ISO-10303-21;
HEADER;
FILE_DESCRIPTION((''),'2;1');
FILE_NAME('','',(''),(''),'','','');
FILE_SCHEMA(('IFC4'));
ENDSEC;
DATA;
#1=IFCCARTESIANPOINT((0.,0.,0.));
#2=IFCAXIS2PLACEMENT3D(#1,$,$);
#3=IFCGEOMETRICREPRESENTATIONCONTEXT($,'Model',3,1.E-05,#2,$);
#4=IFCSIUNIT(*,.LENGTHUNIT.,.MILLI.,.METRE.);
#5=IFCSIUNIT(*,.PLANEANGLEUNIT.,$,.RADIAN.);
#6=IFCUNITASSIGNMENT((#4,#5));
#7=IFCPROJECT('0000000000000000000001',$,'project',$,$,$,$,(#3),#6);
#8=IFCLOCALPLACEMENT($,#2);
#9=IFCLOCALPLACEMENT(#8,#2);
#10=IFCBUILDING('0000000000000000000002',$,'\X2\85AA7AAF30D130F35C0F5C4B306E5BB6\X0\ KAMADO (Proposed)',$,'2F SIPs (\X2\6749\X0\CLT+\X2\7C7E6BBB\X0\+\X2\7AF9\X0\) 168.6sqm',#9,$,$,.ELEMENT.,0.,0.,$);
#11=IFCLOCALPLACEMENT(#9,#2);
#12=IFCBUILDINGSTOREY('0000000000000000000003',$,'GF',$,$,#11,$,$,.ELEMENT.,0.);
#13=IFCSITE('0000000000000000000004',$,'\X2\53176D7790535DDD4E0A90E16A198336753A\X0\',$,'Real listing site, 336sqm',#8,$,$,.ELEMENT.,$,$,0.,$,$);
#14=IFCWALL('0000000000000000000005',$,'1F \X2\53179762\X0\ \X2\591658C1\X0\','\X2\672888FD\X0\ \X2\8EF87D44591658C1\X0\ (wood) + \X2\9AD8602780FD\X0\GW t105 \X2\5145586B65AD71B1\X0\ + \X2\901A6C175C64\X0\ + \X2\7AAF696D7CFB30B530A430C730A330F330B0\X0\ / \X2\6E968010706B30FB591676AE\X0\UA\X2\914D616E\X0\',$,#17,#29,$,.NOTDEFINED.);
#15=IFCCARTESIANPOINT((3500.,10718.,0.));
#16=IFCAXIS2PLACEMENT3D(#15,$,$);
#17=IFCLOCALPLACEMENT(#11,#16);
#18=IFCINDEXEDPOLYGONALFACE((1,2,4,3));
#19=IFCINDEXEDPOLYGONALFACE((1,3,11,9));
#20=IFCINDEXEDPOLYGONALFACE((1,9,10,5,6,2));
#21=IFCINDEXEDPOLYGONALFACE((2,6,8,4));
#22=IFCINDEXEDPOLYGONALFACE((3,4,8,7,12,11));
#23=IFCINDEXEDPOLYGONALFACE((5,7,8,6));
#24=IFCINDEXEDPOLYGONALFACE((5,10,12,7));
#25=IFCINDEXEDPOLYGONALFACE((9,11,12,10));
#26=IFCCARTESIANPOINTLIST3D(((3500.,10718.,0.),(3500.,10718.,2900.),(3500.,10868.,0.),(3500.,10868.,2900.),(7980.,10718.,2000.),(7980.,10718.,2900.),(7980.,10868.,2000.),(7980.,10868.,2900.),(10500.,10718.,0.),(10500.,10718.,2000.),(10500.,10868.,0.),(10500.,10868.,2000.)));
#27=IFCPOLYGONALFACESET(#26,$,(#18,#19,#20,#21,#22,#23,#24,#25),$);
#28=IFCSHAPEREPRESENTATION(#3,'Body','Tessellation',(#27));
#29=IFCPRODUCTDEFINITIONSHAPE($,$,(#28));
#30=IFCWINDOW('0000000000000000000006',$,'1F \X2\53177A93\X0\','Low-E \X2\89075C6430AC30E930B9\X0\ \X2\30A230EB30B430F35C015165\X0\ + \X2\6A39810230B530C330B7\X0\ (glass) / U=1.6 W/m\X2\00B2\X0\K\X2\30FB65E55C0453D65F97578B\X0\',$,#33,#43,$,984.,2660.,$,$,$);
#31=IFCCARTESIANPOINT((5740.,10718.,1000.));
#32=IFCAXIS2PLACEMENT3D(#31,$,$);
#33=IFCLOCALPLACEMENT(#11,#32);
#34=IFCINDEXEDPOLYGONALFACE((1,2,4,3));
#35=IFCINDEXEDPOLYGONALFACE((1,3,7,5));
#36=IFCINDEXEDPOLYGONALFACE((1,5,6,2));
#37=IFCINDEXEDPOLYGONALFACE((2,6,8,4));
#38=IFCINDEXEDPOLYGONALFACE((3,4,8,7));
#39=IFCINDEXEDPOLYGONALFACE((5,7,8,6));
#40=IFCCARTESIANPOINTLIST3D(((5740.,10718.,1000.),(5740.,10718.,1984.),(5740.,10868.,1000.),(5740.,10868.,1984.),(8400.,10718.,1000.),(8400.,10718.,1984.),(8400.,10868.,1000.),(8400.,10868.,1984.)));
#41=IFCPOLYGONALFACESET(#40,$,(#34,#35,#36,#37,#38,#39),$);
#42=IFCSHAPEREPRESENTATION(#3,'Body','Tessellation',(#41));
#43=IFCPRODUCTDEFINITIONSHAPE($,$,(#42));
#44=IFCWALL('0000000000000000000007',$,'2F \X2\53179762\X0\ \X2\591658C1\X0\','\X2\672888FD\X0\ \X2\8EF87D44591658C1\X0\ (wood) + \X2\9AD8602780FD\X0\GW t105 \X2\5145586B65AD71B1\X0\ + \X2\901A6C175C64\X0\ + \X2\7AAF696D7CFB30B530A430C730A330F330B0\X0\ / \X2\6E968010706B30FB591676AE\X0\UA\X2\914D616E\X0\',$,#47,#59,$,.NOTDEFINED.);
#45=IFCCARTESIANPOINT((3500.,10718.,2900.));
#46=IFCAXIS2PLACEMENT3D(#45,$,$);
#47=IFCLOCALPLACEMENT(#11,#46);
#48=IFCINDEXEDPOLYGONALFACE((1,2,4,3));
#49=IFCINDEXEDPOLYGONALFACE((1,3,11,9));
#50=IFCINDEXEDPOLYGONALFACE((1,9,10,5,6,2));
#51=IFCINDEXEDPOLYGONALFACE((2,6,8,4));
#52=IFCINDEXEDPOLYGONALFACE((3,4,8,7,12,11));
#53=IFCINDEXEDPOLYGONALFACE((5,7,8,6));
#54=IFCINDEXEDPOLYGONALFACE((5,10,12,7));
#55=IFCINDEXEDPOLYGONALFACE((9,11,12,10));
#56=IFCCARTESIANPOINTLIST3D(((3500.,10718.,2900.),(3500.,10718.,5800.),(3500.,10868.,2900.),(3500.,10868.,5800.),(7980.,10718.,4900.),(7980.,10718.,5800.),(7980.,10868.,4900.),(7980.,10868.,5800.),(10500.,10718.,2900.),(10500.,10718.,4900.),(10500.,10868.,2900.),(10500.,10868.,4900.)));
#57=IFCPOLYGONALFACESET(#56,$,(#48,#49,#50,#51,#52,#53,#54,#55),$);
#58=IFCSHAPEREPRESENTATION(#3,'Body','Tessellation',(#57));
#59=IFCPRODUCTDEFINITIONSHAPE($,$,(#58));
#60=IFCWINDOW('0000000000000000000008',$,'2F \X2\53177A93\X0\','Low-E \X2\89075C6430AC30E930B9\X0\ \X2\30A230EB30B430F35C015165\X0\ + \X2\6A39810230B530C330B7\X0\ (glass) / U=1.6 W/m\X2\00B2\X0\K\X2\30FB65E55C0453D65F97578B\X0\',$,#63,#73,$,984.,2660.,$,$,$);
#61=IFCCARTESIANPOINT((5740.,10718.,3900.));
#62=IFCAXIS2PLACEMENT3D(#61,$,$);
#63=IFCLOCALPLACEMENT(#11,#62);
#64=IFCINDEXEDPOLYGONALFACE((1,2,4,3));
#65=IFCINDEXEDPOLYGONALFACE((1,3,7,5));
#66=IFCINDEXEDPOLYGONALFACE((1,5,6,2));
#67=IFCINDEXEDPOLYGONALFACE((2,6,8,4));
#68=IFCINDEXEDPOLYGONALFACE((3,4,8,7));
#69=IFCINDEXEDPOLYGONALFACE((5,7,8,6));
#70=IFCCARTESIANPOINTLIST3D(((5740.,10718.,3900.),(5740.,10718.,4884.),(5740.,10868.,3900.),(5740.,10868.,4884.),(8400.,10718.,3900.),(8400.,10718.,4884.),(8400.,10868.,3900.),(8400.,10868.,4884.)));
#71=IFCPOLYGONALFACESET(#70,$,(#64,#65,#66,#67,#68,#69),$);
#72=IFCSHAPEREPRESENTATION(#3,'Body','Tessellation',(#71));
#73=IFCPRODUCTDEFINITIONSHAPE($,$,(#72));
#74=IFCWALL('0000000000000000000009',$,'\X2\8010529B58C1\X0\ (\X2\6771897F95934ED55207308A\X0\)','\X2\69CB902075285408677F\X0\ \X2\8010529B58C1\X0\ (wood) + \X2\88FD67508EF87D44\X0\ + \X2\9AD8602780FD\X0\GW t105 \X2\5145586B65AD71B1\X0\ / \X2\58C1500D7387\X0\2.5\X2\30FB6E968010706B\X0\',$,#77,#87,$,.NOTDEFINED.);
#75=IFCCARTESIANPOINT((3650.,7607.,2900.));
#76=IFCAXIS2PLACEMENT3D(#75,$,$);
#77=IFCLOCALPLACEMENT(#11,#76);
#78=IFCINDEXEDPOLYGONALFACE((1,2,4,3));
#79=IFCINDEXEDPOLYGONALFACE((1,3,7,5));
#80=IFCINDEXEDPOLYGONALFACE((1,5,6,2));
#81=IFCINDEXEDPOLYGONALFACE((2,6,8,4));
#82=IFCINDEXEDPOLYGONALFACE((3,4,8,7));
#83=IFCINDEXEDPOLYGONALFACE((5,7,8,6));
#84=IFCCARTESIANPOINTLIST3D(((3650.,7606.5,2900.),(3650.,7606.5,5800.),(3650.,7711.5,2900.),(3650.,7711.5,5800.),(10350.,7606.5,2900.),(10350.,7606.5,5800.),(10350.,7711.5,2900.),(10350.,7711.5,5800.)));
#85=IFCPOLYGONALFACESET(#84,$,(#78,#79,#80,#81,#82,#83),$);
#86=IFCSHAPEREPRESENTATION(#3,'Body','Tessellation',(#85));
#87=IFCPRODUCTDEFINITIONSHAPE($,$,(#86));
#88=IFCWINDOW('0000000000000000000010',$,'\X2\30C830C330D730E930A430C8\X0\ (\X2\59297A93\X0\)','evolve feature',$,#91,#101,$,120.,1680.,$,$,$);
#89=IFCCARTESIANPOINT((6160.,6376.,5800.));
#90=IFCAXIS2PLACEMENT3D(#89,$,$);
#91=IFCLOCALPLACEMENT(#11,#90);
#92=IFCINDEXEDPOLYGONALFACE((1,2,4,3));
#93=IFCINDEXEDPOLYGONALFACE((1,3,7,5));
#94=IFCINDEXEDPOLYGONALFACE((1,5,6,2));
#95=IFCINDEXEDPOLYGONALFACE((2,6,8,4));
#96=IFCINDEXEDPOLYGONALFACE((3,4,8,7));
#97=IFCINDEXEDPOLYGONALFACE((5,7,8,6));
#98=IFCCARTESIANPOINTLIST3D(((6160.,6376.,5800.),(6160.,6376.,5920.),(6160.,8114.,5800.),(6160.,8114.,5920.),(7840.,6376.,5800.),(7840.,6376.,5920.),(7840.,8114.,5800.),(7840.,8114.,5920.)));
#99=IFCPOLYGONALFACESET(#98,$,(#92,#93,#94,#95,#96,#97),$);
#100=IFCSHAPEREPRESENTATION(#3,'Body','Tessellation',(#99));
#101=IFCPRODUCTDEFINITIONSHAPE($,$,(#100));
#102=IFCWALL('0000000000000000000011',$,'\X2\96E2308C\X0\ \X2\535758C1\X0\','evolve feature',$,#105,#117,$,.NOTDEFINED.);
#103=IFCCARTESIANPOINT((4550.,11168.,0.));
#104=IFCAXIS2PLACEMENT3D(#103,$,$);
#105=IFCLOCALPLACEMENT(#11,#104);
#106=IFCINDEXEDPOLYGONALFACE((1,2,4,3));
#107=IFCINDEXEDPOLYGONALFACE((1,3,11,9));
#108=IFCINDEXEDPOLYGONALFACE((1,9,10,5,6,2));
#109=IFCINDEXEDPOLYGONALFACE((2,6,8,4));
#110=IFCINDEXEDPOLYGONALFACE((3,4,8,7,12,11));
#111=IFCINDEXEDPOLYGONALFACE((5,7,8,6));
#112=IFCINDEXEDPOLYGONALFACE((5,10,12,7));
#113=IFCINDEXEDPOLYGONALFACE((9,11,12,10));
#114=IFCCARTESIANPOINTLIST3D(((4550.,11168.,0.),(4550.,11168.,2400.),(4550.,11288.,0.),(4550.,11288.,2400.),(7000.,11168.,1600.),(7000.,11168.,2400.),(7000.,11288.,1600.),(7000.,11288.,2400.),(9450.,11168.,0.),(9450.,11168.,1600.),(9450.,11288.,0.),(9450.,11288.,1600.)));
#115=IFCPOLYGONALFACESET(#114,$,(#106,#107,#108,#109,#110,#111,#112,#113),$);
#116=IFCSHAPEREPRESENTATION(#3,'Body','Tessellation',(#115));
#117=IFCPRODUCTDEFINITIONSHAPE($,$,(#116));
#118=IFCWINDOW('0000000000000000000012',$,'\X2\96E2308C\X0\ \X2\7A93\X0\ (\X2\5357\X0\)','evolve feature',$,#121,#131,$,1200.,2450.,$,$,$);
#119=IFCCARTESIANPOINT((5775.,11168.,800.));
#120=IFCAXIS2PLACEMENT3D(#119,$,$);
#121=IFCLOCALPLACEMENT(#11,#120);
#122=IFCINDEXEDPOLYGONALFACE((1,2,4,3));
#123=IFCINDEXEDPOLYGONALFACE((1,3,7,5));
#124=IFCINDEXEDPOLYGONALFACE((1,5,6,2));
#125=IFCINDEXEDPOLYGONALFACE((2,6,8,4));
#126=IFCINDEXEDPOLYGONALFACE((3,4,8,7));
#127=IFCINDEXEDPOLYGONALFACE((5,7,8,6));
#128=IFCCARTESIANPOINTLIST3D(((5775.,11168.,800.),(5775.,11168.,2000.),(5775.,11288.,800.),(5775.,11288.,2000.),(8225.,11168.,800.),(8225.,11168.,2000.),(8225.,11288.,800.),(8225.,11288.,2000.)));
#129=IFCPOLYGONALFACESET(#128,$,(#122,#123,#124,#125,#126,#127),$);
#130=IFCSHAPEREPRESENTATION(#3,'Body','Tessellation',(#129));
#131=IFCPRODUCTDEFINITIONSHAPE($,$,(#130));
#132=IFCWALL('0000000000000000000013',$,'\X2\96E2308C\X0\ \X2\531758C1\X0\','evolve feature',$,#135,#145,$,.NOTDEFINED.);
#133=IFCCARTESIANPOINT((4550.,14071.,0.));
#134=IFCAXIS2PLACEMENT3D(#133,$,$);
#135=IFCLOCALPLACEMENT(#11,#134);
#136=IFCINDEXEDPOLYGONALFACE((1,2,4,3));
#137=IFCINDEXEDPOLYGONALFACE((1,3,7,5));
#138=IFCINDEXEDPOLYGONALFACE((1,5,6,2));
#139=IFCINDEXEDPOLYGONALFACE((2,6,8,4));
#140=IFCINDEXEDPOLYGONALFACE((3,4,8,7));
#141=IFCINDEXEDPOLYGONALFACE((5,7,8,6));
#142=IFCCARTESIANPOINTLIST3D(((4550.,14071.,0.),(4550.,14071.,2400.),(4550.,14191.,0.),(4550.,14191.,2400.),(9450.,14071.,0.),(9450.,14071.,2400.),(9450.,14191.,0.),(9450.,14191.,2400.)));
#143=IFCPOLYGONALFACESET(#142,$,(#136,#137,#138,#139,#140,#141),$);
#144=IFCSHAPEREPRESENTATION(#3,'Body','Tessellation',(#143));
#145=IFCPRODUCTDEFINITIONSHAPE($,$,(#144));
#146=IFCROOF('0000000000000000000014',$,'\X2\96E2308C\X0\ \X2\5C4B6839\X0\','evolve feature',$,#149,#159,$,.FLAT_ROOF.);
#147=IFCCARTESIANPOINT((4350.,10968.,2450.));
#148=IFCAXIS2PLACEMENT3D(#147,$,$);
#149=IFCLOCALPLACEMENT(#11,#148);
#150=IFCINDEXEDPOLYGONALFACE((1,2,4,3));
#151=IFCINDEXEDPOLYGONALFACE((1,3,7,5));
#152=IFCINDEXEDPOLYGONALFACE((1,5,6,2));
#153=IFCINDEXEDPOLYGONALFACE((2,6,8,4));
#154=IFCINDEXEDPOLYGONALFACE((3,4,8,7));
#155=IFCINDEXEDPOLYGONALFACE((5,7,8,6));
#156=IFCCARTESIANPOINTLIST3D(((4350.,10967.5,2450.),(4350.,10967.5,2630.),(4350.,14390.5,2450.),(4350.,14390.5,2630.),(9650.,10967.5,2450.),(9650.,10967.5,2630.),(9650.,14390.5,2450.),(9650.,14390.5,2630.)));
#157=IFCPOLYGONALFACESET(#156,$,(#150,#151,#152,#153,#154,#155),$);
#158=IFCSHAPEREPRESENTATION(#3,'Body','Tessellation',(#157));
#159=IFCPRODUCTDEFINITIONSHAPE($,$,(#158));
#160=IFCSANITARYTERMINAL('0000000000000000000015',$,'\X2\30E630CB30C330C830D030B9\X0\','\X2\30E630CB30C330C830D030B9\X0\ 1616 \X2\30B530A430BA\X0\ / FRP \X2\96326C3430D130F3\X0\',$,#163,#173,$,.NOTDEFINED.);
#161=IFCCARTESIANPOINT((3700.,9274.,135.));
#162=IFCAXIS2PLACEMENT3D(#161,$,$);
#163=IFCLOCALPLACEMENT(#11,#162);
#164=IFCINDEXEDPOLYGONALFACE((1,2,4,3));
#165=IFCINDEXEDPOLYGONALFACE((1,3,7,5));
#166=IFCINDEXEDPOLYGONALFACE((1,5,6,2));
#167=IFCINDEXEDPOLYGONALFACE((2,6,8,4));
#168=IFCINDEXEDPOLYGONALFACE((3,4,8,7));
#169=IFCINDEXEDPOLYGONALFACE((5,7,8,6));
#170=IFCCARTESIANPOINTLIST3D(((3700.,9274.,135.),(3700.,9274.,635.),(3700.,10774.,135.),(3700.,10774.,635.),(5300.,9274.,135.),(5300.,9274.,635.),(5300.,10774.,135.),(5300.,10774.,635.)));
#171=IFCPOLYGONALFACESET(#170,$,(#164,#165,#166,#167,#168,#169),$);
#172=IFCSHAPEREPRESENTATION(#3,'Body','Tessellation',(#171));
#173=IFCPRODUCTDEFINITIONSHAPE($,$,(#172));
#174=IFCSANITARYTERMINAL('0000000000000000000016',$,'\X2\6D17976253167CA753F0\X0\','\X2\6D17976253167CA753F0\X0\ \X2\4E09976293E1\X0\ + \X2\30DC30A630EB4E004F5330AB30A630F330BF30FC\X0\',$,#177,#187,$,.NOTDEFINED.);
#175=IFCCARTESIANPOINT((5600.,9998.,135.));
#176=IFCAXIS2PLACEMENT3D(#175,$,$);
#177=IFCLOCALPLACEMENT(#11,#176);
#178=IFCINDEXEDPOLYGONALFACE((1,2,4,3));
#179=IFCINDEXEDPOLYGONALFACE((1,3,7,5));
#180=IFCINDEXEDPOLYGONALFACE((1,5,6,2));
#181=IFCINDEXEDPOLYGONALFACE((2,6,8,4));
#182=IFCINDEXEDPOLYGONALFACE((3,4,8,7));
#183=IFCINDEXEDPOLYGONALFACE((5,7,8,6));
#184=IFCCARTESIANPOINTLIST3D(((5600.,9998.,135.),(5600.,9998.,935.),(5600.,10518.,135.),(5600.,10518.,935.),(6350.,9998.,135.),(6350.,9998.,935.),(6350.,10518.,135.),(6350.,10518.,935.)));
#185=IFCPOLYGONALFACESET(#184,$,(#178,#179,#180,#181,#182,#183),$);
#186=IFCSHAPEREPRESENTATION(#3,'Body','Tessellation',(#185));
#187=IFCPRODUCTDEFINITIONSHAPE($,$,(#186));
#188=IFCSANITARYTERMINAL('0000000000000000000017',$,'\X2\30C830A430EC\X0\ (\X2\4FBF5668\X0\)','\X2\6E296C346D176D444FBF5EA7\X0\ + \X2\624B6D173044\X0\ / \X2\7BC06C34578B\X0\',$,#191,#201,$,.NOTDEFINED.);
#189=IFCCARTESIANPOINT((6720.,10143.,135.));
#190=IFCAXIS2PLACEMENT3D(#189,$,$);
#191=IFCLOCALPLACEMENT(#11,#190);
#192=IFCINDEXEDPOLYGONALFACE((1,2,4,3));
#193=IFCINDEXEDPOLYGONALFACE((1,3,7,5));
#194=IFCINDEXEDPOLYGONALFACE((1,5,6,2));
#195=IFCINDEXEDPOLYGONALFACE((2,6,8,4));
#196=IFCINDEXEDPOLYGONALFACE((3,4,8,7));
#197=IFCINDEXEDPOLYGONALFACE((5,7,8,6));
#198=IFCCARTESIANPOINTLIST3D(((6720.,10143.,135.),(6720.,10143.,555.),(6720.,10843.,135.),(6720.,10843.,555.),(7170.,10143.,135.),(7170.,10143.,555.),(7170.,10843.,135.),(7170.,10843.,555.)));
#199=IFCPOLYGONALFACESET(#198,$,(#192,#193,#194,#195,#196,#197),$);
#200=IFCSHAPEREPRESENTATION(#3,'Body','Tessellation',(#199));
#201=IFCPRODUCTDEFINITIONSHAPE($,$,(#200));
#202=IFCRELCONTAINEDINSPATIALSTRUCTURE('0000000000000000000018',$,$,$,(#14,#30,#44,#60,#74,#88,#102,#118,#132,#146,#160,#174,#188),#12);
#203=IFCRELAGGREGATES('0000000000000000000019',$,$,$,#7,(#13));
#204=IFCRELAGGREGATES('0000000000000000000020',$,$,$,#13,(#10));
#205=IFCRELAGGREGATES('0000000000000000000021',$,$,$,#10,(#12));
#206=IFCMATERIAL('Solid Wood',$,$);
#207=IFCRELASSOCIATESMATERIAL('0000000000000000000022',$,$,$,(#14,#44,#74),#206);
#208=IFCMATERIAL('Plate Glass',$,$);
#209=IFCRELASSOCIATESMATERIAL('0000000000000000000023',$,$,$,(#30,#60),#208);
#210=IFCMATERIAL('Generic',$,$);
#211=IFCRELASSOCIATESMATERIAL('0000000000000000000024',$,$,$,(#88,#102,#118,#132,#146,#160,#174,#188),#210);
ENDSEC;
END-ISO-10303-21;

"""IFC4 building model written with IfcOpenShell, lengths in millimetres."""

from ifc_helpers import new_model, si_unit, frame, frame_2d, origin, place, context, project, spatial, rectangle, extrude, material, element, fill, save


model = new_model("IFC4")

# Units and contexts
model_context = context("Model", 3, precision=1e-05, world=origin())
ifc_project = project(units=[si_unit("LENGTHUNIT", "METRE", prefix="MILLI"), si_unit("PLANEANGLEUNIT", "RADIAN")], contexts=[model_context])

# Site, building, storey
site_placement = place(None, origin())
site = spatial("IfcSite", under=ifc_project, at=site_placement, Name="北海道川上郡標茶町", ObjectType="Real listing site, 336sqm", CompositionType="ELEMENT", RefElevation=0.0)
building_placement = place(site_placement, origin())
building = spatial("IfcBuilding", under=site, at=building_placement, Name="薪窯パン小屋の家 KAMADO (Proposed)", ObjectType="2F SIPs (杉CLT+籾殻+竹) 168.6sqm", CompositionType="ELEMENT", ElevationOfRefHeight=0.0, ElevationOfTerrain=0.0)
storey_placement = place(building_placement, origin())
storey = spatial("IfcBuildingStorey", under=building, at=storey_placement, Name="GF", CompositionType="ELEMENT", Elevation=0.0)

# Shared definitions
ifc_material_1 = material(Name="Generic")

# Wall, opening, window
ifc_material_2 = material(Name="Solid Wood")
wall_1_placement = place(storey_placement, frame((3500.0, 10718.0, 0.0)))
wall_1 = element("IfcWall", 1, at=wall_1_placement, inside=storey, material=ifc_material_2, Name="1F 北面 外壁", Description="木製 軸組外壁 (wood) + 高性能GW t105 充填断熱 + 通気層 + 窯業系サイディング / 準耐火・外皮UA配慮", PredefinedType="NOTDEFINED", context=model_context, shape_type="SweptSolid", body=[
    extrude(rectangle(XDim=7000.0, YDim=150.0, at=frame_2d((3500.0, 75.0))), frame((3500.0, 10718.0, 0.0)), (0.0, 0.0, 1.0), 2900.0),
])
opening_1_placement = place(storey_placement, frame((5740.0, 10718.0, 1000.0)))
opening_1 = element("IfcOpeningElement", 2, at=opening_1_placement, cuts=wall_1, PredefinedType="NOTDEFINED", context=model_context, shape_type="SweptSolid", body=[
    extrude(rectangle(XDim=2660.0, YDim=150.0, at=frame_2d((1330.0, 75.0))), frame((5740.0, 10718.0, 1000.0)), (0.0, 0.0, 1.0), 984.0),
])
ifc_material_3 = material(Name="Plate Glass")
window_1_placement = place(storey_placement, frame((5740.0, 10718.0, 1000.0)))
window_1 = element("IfcWindow", 3, at=window_1_placement, inside=storey, material=ifc_material_3, Name="1F 北窓", Description="Low-E 複層ガラス アルゴン封入 + 樹脂サッシ (glass) / U=1.6 W/m²K・日射取得型", OverallHeight=984.0, OverallWidth=2660.0, context=model_context, shape_type="SweptSolid", body=[
    extrude(rectangle(XDim=2660.0, YDim=150.0, at=frame_2d((1330.0, 75.0))), frame((5740.0, 10718.0, 1000.0)), (0.0, 0.0, 1.0), 984.0),
])
fill(opening_1, window_1)

# Wall, opening, window
wall_2_placement = place(storey_placement, frame((3500.0, 10718.0, 2900.0)))
wall_2 = element("IfcWall", 4, at=wall_2_placement, inside=storey, material=ifc_material_2, Name="2F 北面 外壁", Description="木製 軸組外壁 (wood) + 高性能GW t105 充填断熱 + 通気層 + 窯業系サイディング / 準耐火・外皮UA配慮", PredefinedType="NOTDEFINED", context=model_context, shape_type="SweptSolid", body=[
    extrude(rectangle(XDim=7000.0, YDim=150.0, at=frame_2d((3500.0, 75.0))), frame((3500.0, 10718.0, 2900.0)), (0.0, 0.0, 1.0), 2900.0),
])
opening_2_placement = place(storey_placement, frame((5740.0, 10718.0, 3900.0)))
opening_2 = element("IfcOpeningElement", 5, at=opening_2_placement, cuts=wall_2, PredefinedType="NOTDEFINED", context=model_context, shape_type="SweptSolid", body=[
    extrude(rectangle(XDim=2660.0, YDim=150.0, at=frame_2d((1330.0, 75.0))), frame((5740.0, 10718.0, 3900.0)), (0.0, 0.0, 1.0), 984.0),
])
window_2_placement = place(storey_placement, frame((5740.0, 10718.0, 3900.0)))
window_2 = element("IfcWindow", 6, at=window_2_placement, inside=storey, material=ifc_material_3, Name="2F 北窓", Description="Low-E 複層ガラス アルゴン封入 + 樹脂サッシ (glass) / U=1.6 W/m²K・日射取得型", OverallHeight=984.0, OverallWidth=2660.0, context=model_context, shape_type="SweptSolid", body=[
    extrude(rectangle(XDim=2660.0, YDim=150.0, at=frame_2d((1330.0, 75.0))), frame((5740.0, 10718.0, 3900.0)), (0.0, 0.0, 1.0), 984.0),
])
fill(opening_2, window_2)

# Wall
wall_3_placement = place(storey_placement, frame((3650.0, 7607.0, 2900.0)))
element("IfcWall", 7, at=wall_3_placement, inside=storey, material=ifc_material_2, Name="耐力壁 (東西間仕切り)", Description="構造用合板 耐力壁 (wood) + 製材軸組 + 高性能GW t105 充填断熱 / 壁倍率2.5・準耐火", PredefinedType="NOTDEFINED", context=model_context, shape_type="SweptSolid", body=[
    extrude(rectangle(XDim=6700.0, YDim=105.0, at=frame_2d((3350.0, 52.0))), frame((3650.0, 7607.0, 2900.0)), (0.0, 0.0, 1.0), 2900.0),
])

# Window
window_3_placement = place(storey_placement, frame((6160.0, 6376.0, 5800.0)))
element("IfcWindow", 8, at=window_3_placement, inside=storey, material=ifc_material_1, Name="トップライト (天窓)", Description="evolve feature", OverallHeight=120.0, OverallWidth=1680.0, context=model_context, shape_type="SweptSolid", body=[
    extrude(rectangle(XDim=1680.0, YDim=1738.0, at=frame_2d((840.0, 869.0))), frame((6160.0, 6376.0, 5800.0)), (0.0, 0.0, 1.0), 120.0),
])

# Wall, opening, window
wall_4_placement = place(storey_placement, frame((4550.0, 11168.0, 0.0)))
wall_4 = element("IfcWall", 9, at=wall_4_placement, inside=storey, material=ifc_material_1, Name="離れ 南壁", Description="evolve feature", PredefinedType="NOTDEFINED", context=model_context, shape_type="SweptSolid", body=[
    extrude(rectangle(XDim=4900.0, YDim=120.0, at=frame_2d((2450.0, 60.0))), frame((4550.0, 11168.0, 0.0)), (0.0, 0.0, 1.0), 2400.0),
])
opening_3_placement = place(storey_placement, frame((5775.0, 11168.0, 800.0)))
opening_3 = element("IfcOpeningElement", 10, at=opening_3_placement, cuts=wall_4, PredefinedType="NOTDEFINED", context=model_context, shape_type="SweptSolid", body=[
    extrude(rectangle(XDim=2450.0, YDim=120.0, at=frame_2d((1225.0, 60.0))), frame((5775.0, 11168.0, 800.0)), (0.0, 0.0, 1.0), 1200.0),
])
window_4_placement = place(storey_placement, frame((5775.0, 11168.0, 800.0)))
window_4 = element("IfcWindow", 11, at=window_4_placement, inside=storey, material=ifc_material_1, Name="離れ 窓 (南)", Description="evolve feature", OverallHeight=1200.0, OverallWidth=2450.0, context=model_context, shape_type="SweptSolid", body=[
    extrude(rectangle(XDim=2450.0, YDim=120.0, at=frame_2d((1225.0, 60.0))), frame((5775.0, 11168.0, 800.0)), (0.0, 0.0, 1.0), 1200.0),
])
fill(opening_3, window_4)

# Wall
wall_5_placement = place(storey_placement, frame((4550.0, 14071.0, 0.0)))
element("IfcWall", 12, at=wall_5_placement, inside=storey, material=ifc_material_1, Name="離れ 北壁", Description="evolve feature", PredefinedType="NOTDEFINED", context=model_context, shape_type="SweptSolid", body=[
    extrude(rectangle(XDim=4900.0, YDim=120.0, at=frame_2d((2450.0, 60.0))), frame((4550.0, 14071.0, 0.0)), (0.0, 0.0, 1.0), 2400.0),
])

# Roof
roof_placement = place(storey_placement, frame((4350.0, 10968.0, 2450.0)))
element("IfcRoof", 13, at=roof_placement, inside=storey, material=ifc_material_1, Name="離れ 屋根", Description="evolve feature", PredefinedType="FLAT_ROOF", context=model_context, shape_type="SweptSolid", body=[
    extrude(rectangle(XDim=5300.0, YDim=3423.0, at=frame_2d((2650.0, 1711.0))), frame((4350.0, 10968.0, 2450.0)), (0.0, 0.0, 1.0), 180.0),
])

# Sanitary terminals
sanitary_terminal_1_placement = place(storey_placement, frame((3700.0, 9274.0, 135.0)))
element("IfcSanitaryTerminal", 14, at=sanitary_terminal_1_placement, inside=storey, material=ifc_material_1, Name="ユニットバス", Description="ユニットバス 1616 サイズ / FRP 防水パン", PredefinedType="NOTDEFINED", context=model_context, shape_type="SweptSolid", body=[
    extrude(rectangle(XDim=1600.0, YDim=1500.0, at=frame_2d((800.0, 750.0))), frame((3700.0, 9274.0, 135.0)), (0.0, 0.0, 1.0), 500.0),
])
sanitary_terminal_2_placement = place(storey_placement, frame((5600.0, 9998.0, 135.0)))
element("IfcSanitaryTerminal", 15, at=sanitary_terminal_2_placement, inside=storey, material=ifc_material_1, Name="洗面化粧台", Description="洗面化粧台 三面鏡 + ボウル一体カウンター", PredefinedType="NOTDEFINED", context=model_context, shape_type="SweptSolid", body=[
    extrude(rectangle(XDim=750.0, YDim=520.0, at=frame_2d((375.0, 260.0))), frame((5600.0, 9998.0, 135.0)), (0.0, 0.0, 1.0), 800.0),
])
sanitary_terminal_3_placement = place(storey_placement, frame((6720.0, 10143.0, 135.0)))
element("IfcSanitaryTerminal", 16, at=sanitary_terminal_3_placement, inside=storey, material=ifc_material_1, Name="トイレ (便器)", Description="温水洗浄便座 + 手洗い / 節水型", PredefinedType="NOTDEFINED", context=model_context, shape_type="SweptSolid", body=[
    extrude(rectangle(XDim=450.0, YDim=700.0, at=frame_2d((225.0, 350.0))), frame((6720.0, 10143.0, 135.0)), (0.0, 0.0, 1.0), 420.0),
])

save(model, "model.ifc")
